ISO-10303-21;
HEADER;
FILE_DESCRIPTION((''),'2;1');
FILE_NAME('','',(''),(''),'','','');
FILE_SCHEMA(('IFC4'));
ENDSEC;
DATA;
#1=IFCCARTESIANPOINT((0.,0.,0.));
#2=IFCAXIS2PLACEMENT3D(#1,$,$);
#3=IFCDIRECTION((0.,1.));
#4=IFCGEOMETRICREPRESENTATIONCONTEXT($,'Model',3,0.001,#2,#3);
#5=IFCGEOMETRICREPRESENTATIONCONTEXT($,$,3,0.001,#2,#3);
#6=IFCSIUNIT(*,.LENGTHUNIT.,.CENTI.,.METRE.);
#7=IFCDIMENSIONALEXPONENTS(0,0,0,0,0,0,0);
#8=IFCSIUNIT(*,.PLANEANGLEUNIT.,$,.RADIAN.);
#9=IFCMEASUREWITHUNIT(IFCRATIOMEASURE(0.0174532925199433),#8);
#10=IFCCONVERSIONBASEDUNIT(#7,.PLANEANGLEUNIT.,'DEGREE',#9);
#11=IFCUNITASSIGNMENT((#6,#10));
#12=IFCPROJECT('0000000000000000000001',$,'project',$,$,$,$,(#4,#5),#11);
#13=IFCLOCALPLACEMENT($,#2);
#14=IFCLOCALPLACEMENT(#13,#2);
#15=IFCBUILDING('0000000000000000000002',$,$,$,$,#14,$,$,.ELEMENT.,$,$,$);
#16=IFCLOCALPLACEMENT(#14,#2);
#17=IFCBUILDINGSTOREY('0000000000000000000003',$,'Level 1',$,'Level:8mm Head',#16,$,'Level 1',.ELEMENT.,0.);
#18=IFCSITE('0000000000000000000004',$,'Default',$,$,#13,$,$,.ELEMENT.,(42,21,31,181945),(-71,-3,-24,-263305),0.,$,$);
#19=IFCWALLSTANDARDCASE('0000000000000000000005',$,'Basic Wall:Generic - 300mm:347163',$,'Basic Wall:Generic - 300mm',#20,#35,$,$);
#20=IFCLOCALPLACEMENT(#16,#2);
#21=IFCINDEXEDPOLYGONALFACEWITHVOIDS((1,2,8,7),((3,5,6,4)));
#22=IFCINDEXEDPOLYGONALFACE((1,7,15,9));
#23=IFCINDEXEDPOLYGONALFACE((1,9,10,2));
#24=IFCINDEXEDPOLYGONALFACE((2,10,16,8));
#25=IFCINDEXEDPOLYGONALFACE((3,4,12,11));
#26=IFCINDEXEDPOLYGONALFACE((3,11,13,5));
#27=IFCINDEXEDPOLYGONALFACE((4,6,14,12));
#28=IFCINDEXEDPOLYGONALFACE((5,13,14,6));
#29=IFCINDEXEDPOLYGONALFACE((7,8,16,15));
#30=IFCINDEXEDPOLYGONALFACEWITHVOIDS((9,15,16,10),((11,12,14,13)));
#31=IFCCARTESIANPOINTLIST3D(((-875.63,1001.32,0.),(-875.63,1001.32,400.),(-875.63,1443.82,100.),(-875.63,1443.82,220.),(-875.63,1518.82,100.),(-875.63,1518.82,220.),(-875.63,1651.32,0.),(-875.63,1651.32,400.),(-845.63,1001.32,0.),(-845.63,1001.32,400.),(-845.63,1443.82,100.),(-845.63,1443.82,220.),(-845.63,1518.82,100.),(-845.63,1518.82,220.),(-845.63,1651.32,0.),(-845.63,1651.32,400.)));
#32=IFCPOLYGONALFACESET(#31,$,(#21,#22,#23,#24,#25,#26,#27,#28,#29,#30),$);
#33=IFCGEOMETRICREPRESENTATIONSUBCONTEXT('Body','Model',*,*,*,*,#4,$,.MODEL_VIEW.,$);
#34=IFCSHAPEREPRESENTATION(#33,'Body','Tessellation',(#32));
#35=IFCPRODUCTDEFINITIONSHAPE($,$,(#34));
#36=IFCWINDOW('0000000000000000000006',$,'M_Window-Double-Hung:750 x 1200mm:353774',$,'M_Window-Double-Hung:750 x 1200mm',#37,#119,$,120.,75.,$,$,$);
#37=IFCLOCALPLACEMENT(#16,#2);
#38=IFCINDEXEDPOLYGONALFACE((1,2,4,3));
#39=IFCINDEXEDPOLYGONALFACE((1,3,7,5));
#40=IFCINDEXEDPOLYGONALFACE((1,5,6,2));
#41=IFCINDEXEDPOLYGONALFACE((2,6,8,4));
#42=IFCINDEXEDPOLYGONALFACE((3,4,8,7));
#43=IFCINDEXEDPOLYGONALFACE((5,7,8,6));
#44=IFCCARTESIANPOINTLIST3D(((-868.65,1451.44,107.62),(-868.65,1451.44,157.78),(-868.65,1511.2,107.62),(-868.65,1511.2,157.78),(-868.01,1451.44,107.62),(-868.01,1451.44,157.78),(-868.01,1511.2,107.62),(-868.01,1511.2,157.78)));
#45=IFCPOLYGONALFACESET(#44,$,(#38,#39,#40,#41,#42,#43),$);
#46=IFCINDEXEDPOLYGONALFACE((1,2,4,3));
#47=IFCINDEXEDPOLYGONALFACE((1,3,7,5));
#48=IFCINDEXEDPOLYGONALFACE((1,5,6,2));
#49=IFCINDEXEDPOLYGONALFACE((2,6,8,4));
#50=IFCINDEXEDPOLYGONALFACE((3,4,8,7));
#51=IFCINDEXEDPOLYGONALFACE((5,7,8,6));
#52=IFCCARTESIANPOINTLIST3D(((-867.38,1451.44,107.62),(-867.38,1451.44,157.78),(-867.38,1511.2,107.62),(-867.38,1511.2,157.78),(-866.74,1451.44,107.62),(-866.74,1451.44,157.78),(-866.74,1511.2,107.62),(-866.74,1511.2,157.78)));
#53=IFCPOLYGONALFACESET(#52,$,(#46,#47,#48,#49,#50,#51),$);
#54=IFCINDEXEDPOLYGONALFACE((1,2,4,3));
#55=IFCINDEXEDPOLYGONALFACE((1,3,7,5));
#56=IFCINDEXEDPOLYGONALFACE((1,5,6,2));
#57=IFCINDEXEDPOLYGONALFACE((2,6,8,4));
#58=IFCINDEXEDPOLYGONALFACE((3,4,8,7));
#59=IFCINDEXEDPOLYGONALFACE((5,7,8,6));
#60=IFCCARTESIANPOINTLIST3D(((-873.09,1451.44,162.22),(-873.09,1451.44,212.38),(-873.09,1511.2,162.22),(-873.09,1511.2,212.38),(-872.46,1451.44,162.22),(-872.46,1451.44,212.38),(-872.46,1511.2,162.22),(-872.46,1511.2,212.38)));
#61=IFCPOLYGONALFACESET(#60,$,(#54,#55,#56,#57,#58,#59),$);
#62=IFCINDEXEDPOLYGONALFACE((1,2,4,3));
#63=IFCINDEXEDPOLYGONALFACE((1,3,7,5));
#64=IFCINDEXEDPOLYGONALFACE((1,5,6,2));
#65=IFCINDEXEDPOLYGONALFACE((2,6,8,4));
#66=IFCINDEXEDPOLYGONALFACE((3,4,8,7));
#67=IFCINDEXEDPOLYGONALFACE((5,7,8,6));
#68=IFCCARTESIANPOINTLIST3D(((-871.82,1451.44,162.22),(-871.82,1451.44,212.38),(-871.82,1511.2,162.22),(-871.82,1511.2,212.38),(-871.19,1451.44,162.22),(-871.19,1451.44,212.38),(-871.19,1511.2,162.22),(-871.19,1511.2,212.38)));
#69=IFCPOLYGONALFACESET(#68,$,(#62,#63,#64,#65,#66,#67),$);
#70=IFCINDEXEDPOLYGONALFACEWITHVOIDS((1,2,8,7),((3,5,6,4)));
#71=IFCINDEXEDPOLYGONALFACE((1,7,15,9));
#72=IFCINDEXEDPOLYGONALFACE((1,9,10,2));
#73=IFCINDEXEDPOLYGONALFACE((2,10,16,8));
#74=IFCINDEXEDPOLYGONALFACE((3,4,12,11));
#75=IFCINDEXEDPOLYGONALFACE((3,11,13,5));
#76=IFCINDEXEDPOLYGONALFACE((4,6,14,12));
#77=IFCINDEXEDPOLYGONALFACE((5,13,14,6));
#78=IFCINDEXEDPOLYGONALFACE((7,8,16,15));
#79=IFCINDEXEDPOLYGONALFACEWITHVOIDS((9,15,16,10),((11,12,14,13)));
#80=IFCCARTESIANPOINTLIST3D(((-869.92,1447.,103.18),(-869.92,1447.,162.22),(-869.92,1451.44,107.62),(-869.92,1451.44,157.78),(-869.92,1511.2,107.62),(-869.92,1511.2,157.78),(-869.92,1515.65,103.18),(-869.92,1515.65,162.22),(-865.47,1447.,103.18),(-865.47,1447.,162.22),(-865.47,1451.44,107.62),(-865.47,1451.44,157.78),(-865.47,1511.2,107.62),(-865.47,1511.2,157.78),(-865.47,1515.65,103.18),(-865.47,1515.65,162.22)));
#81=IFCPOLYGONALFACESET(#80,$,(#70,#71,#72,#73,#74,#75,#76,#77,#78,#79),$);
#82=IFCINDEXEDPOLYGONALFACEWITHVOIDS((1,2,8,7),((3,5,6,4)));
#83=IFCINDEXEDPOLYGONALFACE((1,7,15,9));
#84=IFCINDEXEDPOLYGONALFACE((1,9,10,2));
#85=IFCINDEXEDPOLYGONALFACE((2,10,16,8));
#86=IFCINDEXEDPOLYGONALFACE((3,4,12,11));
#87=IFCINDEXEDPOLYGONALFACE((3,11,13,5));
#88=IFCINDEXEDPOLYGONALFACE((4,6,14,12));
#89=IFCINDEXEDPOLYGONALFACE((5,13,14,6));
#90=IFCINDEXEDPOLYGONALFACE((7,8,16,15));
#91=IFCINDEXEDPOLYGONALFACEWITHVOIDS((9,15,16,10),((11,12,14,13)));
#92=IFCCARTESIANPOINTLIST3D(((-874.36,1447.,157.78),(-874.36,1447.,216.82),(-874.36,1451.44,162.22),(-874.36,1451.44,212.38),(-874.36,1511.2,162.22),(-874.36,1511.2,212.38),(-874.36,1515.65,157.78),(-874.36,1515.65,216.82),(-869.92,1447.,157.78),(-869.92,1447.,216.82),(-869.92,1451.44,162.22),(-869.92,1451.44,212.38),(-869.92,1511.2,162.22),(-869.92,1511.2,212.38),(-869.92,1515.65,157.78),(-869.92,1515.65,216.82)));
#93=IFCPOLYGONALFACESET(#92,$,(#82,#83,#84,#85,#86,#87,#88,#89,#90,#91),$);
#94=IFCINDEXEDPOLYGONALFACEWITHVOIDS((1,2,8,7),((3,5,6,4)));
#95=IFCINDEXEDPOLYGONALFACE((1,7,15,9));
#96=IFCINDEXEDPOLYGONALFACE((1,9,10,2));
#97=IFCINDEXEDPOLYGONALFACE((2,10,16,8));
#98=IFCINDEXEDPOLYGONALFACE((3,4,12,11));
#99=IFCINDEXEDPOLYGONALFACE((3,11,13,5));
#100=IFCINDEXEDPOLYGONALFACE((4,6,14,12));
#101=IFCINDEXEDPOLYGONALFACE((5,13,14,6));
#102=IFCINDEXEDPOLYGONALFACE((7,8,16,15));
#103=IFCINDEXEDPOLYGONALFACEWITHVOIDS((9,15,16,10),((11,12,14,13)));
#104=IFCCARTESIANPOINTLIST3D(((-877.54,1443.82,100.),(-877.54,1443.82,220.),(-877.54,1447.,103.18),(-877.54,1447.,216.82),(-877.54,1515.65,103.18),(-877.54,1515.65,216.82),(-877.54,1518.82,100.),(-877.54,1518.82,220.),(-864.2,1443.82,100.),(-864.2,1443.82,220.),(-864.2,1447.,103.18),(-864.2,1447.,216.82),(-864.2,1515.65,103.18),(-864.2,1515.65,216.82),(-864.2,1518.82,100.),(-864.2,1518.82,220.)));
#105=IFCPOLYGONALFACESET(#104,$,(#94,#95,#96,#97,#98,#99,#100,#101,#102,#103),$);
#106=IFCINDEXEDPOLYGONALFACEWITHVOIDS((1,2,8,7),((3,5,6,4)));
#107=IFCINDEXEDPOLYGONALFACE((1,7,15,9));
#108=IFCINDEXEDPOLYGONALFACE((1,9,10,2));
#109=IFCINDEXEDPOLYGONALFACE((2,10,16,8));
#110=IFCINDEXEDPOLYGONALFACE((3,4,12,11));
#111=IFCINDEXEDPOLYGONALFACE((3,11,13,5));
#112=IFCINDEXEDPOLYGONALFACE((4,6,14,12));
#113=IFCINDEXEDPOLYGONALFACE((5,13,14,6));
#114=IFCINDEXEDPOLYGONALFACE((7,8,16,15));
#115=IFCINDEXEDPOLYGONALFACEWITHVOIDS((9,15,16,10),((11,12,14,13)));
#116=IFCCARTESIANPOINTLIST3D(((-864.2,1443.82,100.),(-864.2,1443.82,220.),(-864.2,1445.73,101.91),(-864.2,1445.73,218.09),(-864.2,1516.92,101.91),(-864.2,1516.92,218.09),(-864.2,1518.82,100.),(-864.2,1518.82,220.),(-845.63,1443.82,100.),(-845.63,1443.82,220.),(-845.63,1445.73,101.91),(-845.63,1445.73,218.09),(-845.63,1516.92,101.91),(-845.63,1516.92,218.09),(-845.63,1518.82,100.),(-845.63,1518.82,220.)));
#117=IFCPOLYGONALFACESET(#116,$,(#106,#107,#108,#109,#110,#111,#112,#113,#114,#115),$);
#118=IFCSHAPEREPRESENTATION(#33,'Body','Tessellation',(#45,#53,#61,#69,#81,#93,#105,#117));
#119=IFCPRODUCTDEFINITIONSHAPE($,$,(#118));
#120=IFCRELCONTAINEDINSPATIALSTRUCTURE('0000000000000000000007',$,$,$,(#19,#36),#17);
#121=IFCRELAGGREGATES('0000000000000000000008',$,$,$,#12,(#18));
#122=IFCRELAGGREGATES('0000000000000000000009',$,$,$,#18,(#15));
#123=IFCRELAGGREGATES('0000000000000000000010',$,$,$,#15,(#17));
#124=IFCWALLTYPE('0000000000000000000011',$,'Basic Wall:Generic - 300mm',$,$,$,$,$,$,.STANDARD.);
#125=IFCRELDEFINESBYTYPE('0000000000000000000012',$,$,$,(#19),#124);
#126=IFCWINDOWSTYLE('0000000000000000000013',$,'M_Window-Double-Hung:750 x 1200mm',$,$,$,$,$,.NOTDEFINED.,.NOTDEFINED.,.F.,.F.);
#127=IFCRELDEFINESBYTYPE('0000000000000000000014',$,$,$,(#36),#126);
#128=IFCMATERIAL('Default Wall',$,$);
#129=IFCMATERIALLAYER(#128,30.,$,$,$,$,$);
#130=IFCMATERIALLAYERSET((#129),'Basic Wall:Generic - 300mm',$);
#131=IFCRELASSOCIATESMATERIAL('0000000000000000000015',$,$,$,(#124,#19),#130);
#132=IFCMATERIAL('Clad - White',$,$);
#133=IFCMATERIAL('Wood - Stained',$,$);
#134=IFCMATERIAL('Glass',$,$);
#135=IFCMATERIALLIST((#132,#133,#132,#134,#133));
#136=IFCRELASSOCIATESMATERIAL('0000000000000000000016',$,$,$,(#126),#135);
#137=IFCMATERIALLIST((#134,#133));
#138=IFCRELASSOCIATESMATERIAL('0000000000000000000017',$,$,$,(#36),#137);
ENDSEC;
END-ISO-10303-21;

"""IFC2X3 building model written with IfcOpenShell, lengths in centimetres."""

from ifc_helpers import new_model, entity, si_unit, converted_unit, direction, frame, frame_2d, origin, origin_2d_with_axis, place, context, subcontext, project, spatial, polyline, rectangle, outline, extrude, source, transform, mapped, material, material_list, layer, layer_set, layer_usage, type_object, type_shapes, element, fill, save


model = new_model("IFC2X3")

# Units and contexts
model_context = context("Model", 3, precision=0.001, world=origin(), true_north=direction((0.0, 1.0)))
context_of_model = context(None, 3, precision=0.001, world=origin(), true_north=direction((0.0, 1.0)))
body_context = subcontext(model_context, "Body", "Model", "MODEL_VIEW")
ifc_project = project(units=[si_unit("LENGTHUNIT", "METRE", prefix="CENTI"), converted_unit("PLANEANGLEUNIT", "DEGREE", entity("IfcRatioMeasure", 0.0174532925199433), si_unit("PLANEANGLEUNIT", "RADIAN"), dimensions=[0, 0, 0, 0, 0, 0, 0])], contexts=[model_context, context_of_model])

# Site, building, storey
site_placement = place(None, origin())
site = spatial("IfcSite", under=ifc_project, at=site_placement, Name="Default", CompositionType="ELEMENT", RefLatitude=(42, 21, 31, 181945), RefLongitude=(-71, -3, -24, -263305), RefElevation=0.0)
building_placement = place(site_placement, origin())
building = spatial("IfcBuilding", under=site, at=building_placement, CompositionType="ELEMENT")
storey_placement = place(building_placement, origin())
storey = spatial("IfcBuildingStorey", under=building, at=storey_placement, Name="Level 1", ObjectType="Level:8mm Head", LongName="Level 1", CompositionType="ELEMENT", Elevation=0.0)

# Wall, opening, window
ifc_material_1 = material(Name="Default Wall")
ifc_layer_1 = layer(ifc_material_1, 30.0)
ifc_layer_set_1 = layer_set([ifc_layer_1], Name="Basic Wall:Generic - 300mm")
ifc_layer_usage_1 = layer_usage(ifc_layer_set_1, "AXIS2", "POSITIVE", -15.0)
wall_type = type_object("IfcWallType", Name="Basic Wall:Generic - 300mm", PredefinedType="STANDARD", material=ifc_layer_set_1)
wall_1_placement = place(storey_placement, frame((-860.63, 1001.32, 0.0), z_axis=(0.0, 0.0, 1.0), x_axis=(0.0, 1.0, 0.0)))
wall_1 = element("IfcWallStandardCase", 1, at=wall_1_placement, inside=storey, type_object=wall_type, material=ifc_layer_usage_1, Name="Basic Wall:Generic - 300mm:347163", ObjectType="Basic Wall:Generic - 300mm", context=body_context, shape_type="SweptSolid", body=[
    extrude(rectangle(XDim=650.0, YDim=30.0, at=frame_2d((325.0, 0.0), x_axis=(-1.0, 0.0))), origin(), (0.0, 0.0, 1.0), 400.0),
])
opening_1_placement = place(wall_1_placement, frame((442.5, -15.0, 100.0)))
opening_1 = element("IfcOpeningElement", 2, at=opening_1_placement, cuts=wall_1, ObjectType="Opening", context=body_context, shape_type="SweptSolid", body=[
    extrude(rectangle(XDim=120.0, YDim=75.0, at=frame_2d((60.0, 37.5), x_axis=(-1.0, 0.0))), frame((0.0, 0.0, 0.0), z_axis=(0.0, 1.0, 0.0), x_axis=(0.0, 0.0, 1.0)), (0.0, 0.0, 1.0), 30.0),
])
ifc_material_2 = material(Name="Glass")
ifc_material_3 = material(Name="Wood - Stained")
ifc_material_list_1 = material_list([ifc_material_2, ifc_material_3])
ifc_material_4 = material(Name="Clad - White")
ifc_material_list_2 = material_list([ifc_material_4, ifc_material_3, ifc_material_4, ifc_material_2, ifc_material_3])
window_style = type_object("IfcWindowStyle", Name="M_Window-Double-Hung:750 x 1200mm", ConstructionType="NOTDEFINED", OperationType="NOTDEFINED", ParameterTakesPrecedence=False, Sizeable=False, material=ifc_material_list_2)
shared_shape_1 = source(origin(), body_context, "Body", "SweptSolid", [
    extrude(rectangle(XDim=59.76, YDim=0.63, at=frame_2d((0.0, 0.0), x_axis=(1.0, 0.0))), frame((37.5, 22.7, 7.62), z_axis=(0.0, 0.0, 1.0), x_axis=(-1.0, 0.0, 0.0)), (0.0, 0.0, 1.0), 50.16),
    extrude(rectangle(XDim=0.63, YDim=59.76, at=origin_2d_with_axis()), frame((37.5, 21.43, 7.62), z_axis=(0.0, 0.0, 1.0), x_axis=(0.0, -1.0, 0.0)), (0.0, 0.0, 1.0), 50.16),
    extrude(rectangle(XDim=59.76, YDim=0.63, at=frame_2d((0.0, 0.0), x_axis=(1.0, 0.0))), frame((37.5, 27.14, 62.22), z_axis=(0.0, 0.0, 1.0), x_axis=(-1.0, 0.0, 0.0)), (0.0, 0.0, 1.0), 50.16),
    extrude(rectangle(XDim=0.63, YDim=59.76, at=frame_2d((0.0, 0.0), x_axis=(1.0, 0.0))), frame((37.5, 25.87, 62.22), z_axis=(0.0, 0.0, 1.0), x_axis=(0.0, -1.0, 0.0)), (0.0, 0.0, 1.0), 50.16),
    extrude(outline(polyline([(-34.32, -29.52), (34.32, -29.52), (34.32, 29.52), (-34.32, 29.52), (-34.32, -29.52)]), holes=[polyline([(29.88, -25.08), (-29.88, -25.08), (-29.88, 25.08), (29.88, 25.08), (29.88, -25.08)])]), frame((37.5, 19.84, 32.7), z_axis=(0.0, 1.0, 0.0), x_axis=(1.0, 0.0, 0.0)), (0.0, 0.0, 1.0), 4.45),
    extrude(outline(polyline([(-34.33, -29.52), (34.32, -29.52), (34.33, 29.52), (-34.32, 29.52), (-34.33, -29.52)]), holes=[polyline([(29.88, -25.08), (-29.88, -25.08), (-29.88, 25.08), (29.88, 25.08), (29.88, -25.08)])]), frame((37.5, 24.28, 87.3), z_axis=(0.0, 1.0, 0.0), x_axis=(1.0, 0.0, 0.0)), (0.0, 0.0, 1.0), 4.45),
    extrude(outline(polyline([(-37.5, -60.0), (37.5, -60.0), (37.5, 60.0), (-37.5, 60.0), (-37.5, -60.0)]), holes=[polyline([(34.32, -56.82), (-34.32, -56.82), (-34.32, 56.82), (34.32, 56.82), (34.32, -56.82)])]), frame((37.5, 18.57, 60.0), z_axis=(0.0, 1.0, 0.0), x_axis=(1.0, 0.0, 0.0)), (0.0, 0.0, 1.0), 13.33),
    extrude(outline(polyline([(-60.0, -37.5), (60.0, -37.5), (60.0, 37.5), (-60.0, 37.5), (-60.0, -37.5)]), holes=[polyline([(-58.09, -35.59), (-58.09, 35.59), (58.09, 35.59), (58.09, -35.59), (-58.09, -35.59)])]), frame((37.5, 0.0, 60.0), z_axis=(0.0, 1.0, 0.0), x_axis=(0.0, 0.0, -1.0)), (0.0, 0.0, 1.0), 18.57),
])
type_shapes(window_style, [shared_shape_1])
window_1_placement = place(opening_1_placement, origin())
window_1 = element("IfcWindow", 3, at=window_1_placement, inside=storey, type_object=window_style, material=ifc_material_list_1, Name="M_Window-Double-Hung:750 x 1200mm:353774", ObjectType="M_Window-Double-Hung:750 x 1200mm", OverallHeight=120.0, OverallWidth=75.0, context=body_context, shape_type="MappedRepresentation", body=[
    mapped(shared_shape_1, transform((0.0, 0.0, 0.0), scale=1.0)),
])
fill(opening_1, window_1)

save(model, "model.ifc")
